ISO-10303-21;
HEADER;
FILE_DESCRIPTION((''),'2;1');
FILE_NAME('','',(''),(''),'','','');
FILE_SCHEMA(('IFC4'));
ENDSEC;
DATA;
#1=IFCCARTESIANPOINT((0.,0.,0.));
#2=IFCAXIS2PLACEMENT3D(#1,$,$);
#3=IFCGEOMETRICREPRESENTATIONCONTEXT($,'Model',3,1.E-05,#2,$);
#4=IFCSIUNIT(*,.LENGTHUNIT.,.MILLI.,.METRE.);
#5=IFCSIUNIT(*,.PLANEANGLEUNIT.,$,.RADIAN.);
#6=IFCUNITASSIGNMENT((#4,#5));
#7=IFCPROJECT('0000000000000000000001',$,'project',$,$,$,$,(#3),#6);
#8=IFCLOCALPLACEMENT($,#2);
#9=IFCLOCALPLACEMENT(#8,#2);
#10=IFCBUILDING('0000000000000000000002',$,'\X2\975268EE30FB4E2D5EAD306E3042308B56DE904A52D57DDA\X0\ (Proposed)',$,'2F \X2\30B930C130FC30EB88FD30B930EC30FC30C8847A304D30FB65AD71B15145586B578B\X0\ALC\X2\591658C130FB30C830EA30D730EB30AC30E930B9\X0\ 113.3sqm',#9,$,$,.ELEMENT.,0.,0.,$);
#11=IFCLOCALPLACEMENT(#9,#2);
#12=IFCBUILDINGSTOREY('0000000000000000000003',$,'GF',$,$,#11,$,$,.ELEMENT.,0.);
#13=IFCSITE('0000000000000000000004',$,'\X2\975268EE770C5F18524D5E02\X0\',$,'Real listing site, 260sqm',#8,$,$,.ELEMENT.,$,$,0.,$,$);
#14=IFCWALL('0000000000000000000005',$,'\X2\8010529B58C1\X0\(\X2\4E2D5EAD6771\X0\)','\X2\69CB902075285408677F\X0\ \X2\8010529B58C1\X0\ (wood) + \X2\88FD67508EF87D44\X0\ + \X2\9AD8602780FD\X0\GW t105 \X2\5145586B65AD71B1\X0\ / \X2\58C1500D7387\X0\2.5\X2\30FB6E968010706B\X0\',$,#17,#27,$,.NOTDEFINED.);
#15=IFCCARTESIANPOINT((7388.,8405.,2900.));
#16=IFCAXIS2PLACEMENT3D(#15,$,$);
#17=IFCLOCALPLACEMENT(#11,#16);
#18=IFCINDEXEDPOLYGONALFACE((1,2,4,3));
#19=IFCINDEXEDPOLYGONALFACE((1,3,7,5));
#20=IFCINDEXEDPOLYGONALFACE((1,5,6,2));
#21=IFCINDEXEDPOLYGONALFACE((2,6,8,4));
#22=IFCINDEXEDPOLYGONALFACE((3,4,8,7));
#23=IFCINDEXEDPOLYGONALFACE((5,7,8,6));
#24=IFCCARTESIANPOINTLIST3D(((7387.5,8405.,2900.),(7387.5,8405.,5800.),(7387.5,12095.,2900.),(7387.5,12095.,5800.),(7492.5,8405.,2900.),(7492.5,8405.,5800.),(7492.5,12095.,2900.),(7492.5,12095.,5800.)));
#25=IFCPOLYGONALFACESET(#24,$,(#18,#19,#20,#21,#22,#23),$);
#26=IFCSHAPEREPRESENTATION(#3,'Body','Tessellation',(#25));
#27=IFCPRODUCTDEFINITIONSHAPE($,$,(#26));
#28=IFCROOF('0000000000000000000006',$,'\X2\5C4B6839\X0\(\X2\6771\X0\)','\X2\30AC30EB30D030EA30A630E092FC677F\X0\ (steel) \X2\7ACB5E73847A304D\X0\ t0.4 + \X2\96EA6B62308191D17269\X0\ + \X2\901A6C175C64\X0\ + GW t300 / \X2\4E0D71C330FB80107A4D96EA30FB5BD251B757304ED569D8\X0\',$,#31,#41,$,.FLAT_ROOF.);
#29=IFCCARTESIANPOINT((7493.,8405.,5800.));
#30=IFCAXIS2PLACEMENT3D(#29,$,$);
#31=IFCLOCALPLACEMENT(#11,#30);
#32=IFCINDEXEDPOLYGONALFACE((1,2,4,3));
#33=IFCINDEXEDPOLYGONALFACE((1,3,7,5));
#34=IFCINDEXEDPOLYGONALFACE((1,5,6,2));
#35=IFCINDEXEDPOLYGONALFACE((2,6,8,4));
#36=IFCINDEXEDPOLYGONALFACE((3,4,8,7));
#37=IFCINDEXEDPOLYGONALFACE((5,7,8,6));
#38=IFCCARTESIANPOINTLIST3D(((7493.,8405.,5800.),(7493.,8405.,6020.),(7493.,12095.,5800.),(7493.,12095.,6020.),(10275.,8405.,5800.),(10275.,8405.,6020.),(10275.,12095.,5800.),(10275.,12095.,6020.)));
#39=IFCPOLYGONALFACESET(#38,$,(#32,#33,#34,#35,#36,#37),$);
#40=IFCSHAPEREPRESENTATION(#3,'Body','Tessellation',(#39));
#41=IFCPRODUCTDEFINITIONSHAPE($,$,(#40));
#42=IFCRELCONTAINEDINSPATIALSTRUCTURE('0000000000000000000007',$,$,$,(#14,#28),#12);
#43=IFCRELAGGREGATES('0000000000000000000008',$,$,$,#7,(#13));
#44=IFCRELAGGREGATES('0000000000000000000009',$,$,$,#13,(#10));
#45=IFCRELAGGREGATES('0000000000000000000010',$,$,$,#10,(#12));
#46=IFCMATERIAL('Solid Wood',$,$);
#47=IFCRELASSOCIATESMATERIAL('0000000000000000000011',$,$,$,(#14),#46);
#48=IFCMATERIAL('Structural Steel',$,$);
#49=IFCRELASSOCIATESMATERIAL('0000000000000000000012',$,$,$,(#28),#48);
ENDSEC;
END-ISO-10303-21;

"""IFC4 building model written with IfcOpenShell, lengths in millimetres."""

from ifc_helpers import new_model, si_unit, frame, frame_2d, origin, place, context, project, spatial, rectangle, extrude, material, element, save


model = new_model("IFC4")

# Units and contexts
model_context = context("Model", 3, precision=1e-05, world=origin())
ifc_project = project(units=[si_unit("LENGTHUNIT", "METRE", prefix="MILLI"), si_unit("PLANEANGLEUNIT", "RADIAN")], contexts=[model_context])

# Site, building, storey
site_placement = place(None, origin())
site = spatial("IfcSite", under=ifc_project, at=site_placement, Name="青森県弘前市", ObjectType="Real listing site, 260sqm", CompositionType="ELEMENT", RefElevation=0.0)
building_placement = place(site_placement, origin())
building = spatial("IfcBuilding", under=site, at=building_placement, Name="青森・中庭のある回遊動線 (Proposed)", ObjectType="2F スチール製スレート葺き・断熱充填型ALC外壁・トリプルガラス 113.3sqm", CompositionType="ELEMENT", ElevationOfRefHeight=0.0, ElevationOfTerrain=0.0)
storey_placement = place(building_placement, origin())
storey = spatial("IfcBuildingStorey", under=building, at=storey_placement, Name="GF", CompositionType="ELEMENT", Elevation=0.0)

# Shared definitions
ifc_material_1 = material(Name="Solid Wood")

# Wall
wall_1_placement = place(storey_placement, frame((7388.0, 8405.0, 2900.0)))
element("IfcWall", 1, at=wall_1_placement, inside=storey, material=ifc_material_1, Name="耐力壁(中庭東)", Description="構造用合板 耐力壁 (wood) + 製材軸組 + 高性能GW t105 充填断熱 / 壁倍率2.5・準耐火", PredefinedType="NOTDEFINED", context=model_context, shape_type="SweptSolid", body=[
    extrude(rectangle(XDim=105.0, YDim=3690.0, at=frame_2d((52.0, 1845.0))), frame((7388.0, 8405.0, 2900.0)), (0.0, 0.0, 1.0), 2900.0),
])

# Roof
ifc_material_2 = material(Name="Structural Steel")
for number, where, name in (
    (2, (7493.0, 8405.0, 5800.0), "屋根(東)"),
):
    element("IfcRoof", number, at=place(storey_placement, frame(where)), inside=storey, material=ifc_material_2, Name=name, Description="ガルバリウム鋼板 (steel) 立平葺き t0.4 + 雪止め金物 + 通気層 + GW t300 / 不燃・耐積雪・寒冷地仕様", PredefinedType="FLAT_ROOF", context=model_context, shape_type="SweptSolid", body=[
        extrude(rectangle(XDim=2782.0, YDim=3690.0, at=frame_2d((1391.0, 1845.0))), frame((7493.0, 8405.0, 5800.0)), (0.0, 0.0, 1.0), 220.0),
    ])

save(model, "model.ifc")
